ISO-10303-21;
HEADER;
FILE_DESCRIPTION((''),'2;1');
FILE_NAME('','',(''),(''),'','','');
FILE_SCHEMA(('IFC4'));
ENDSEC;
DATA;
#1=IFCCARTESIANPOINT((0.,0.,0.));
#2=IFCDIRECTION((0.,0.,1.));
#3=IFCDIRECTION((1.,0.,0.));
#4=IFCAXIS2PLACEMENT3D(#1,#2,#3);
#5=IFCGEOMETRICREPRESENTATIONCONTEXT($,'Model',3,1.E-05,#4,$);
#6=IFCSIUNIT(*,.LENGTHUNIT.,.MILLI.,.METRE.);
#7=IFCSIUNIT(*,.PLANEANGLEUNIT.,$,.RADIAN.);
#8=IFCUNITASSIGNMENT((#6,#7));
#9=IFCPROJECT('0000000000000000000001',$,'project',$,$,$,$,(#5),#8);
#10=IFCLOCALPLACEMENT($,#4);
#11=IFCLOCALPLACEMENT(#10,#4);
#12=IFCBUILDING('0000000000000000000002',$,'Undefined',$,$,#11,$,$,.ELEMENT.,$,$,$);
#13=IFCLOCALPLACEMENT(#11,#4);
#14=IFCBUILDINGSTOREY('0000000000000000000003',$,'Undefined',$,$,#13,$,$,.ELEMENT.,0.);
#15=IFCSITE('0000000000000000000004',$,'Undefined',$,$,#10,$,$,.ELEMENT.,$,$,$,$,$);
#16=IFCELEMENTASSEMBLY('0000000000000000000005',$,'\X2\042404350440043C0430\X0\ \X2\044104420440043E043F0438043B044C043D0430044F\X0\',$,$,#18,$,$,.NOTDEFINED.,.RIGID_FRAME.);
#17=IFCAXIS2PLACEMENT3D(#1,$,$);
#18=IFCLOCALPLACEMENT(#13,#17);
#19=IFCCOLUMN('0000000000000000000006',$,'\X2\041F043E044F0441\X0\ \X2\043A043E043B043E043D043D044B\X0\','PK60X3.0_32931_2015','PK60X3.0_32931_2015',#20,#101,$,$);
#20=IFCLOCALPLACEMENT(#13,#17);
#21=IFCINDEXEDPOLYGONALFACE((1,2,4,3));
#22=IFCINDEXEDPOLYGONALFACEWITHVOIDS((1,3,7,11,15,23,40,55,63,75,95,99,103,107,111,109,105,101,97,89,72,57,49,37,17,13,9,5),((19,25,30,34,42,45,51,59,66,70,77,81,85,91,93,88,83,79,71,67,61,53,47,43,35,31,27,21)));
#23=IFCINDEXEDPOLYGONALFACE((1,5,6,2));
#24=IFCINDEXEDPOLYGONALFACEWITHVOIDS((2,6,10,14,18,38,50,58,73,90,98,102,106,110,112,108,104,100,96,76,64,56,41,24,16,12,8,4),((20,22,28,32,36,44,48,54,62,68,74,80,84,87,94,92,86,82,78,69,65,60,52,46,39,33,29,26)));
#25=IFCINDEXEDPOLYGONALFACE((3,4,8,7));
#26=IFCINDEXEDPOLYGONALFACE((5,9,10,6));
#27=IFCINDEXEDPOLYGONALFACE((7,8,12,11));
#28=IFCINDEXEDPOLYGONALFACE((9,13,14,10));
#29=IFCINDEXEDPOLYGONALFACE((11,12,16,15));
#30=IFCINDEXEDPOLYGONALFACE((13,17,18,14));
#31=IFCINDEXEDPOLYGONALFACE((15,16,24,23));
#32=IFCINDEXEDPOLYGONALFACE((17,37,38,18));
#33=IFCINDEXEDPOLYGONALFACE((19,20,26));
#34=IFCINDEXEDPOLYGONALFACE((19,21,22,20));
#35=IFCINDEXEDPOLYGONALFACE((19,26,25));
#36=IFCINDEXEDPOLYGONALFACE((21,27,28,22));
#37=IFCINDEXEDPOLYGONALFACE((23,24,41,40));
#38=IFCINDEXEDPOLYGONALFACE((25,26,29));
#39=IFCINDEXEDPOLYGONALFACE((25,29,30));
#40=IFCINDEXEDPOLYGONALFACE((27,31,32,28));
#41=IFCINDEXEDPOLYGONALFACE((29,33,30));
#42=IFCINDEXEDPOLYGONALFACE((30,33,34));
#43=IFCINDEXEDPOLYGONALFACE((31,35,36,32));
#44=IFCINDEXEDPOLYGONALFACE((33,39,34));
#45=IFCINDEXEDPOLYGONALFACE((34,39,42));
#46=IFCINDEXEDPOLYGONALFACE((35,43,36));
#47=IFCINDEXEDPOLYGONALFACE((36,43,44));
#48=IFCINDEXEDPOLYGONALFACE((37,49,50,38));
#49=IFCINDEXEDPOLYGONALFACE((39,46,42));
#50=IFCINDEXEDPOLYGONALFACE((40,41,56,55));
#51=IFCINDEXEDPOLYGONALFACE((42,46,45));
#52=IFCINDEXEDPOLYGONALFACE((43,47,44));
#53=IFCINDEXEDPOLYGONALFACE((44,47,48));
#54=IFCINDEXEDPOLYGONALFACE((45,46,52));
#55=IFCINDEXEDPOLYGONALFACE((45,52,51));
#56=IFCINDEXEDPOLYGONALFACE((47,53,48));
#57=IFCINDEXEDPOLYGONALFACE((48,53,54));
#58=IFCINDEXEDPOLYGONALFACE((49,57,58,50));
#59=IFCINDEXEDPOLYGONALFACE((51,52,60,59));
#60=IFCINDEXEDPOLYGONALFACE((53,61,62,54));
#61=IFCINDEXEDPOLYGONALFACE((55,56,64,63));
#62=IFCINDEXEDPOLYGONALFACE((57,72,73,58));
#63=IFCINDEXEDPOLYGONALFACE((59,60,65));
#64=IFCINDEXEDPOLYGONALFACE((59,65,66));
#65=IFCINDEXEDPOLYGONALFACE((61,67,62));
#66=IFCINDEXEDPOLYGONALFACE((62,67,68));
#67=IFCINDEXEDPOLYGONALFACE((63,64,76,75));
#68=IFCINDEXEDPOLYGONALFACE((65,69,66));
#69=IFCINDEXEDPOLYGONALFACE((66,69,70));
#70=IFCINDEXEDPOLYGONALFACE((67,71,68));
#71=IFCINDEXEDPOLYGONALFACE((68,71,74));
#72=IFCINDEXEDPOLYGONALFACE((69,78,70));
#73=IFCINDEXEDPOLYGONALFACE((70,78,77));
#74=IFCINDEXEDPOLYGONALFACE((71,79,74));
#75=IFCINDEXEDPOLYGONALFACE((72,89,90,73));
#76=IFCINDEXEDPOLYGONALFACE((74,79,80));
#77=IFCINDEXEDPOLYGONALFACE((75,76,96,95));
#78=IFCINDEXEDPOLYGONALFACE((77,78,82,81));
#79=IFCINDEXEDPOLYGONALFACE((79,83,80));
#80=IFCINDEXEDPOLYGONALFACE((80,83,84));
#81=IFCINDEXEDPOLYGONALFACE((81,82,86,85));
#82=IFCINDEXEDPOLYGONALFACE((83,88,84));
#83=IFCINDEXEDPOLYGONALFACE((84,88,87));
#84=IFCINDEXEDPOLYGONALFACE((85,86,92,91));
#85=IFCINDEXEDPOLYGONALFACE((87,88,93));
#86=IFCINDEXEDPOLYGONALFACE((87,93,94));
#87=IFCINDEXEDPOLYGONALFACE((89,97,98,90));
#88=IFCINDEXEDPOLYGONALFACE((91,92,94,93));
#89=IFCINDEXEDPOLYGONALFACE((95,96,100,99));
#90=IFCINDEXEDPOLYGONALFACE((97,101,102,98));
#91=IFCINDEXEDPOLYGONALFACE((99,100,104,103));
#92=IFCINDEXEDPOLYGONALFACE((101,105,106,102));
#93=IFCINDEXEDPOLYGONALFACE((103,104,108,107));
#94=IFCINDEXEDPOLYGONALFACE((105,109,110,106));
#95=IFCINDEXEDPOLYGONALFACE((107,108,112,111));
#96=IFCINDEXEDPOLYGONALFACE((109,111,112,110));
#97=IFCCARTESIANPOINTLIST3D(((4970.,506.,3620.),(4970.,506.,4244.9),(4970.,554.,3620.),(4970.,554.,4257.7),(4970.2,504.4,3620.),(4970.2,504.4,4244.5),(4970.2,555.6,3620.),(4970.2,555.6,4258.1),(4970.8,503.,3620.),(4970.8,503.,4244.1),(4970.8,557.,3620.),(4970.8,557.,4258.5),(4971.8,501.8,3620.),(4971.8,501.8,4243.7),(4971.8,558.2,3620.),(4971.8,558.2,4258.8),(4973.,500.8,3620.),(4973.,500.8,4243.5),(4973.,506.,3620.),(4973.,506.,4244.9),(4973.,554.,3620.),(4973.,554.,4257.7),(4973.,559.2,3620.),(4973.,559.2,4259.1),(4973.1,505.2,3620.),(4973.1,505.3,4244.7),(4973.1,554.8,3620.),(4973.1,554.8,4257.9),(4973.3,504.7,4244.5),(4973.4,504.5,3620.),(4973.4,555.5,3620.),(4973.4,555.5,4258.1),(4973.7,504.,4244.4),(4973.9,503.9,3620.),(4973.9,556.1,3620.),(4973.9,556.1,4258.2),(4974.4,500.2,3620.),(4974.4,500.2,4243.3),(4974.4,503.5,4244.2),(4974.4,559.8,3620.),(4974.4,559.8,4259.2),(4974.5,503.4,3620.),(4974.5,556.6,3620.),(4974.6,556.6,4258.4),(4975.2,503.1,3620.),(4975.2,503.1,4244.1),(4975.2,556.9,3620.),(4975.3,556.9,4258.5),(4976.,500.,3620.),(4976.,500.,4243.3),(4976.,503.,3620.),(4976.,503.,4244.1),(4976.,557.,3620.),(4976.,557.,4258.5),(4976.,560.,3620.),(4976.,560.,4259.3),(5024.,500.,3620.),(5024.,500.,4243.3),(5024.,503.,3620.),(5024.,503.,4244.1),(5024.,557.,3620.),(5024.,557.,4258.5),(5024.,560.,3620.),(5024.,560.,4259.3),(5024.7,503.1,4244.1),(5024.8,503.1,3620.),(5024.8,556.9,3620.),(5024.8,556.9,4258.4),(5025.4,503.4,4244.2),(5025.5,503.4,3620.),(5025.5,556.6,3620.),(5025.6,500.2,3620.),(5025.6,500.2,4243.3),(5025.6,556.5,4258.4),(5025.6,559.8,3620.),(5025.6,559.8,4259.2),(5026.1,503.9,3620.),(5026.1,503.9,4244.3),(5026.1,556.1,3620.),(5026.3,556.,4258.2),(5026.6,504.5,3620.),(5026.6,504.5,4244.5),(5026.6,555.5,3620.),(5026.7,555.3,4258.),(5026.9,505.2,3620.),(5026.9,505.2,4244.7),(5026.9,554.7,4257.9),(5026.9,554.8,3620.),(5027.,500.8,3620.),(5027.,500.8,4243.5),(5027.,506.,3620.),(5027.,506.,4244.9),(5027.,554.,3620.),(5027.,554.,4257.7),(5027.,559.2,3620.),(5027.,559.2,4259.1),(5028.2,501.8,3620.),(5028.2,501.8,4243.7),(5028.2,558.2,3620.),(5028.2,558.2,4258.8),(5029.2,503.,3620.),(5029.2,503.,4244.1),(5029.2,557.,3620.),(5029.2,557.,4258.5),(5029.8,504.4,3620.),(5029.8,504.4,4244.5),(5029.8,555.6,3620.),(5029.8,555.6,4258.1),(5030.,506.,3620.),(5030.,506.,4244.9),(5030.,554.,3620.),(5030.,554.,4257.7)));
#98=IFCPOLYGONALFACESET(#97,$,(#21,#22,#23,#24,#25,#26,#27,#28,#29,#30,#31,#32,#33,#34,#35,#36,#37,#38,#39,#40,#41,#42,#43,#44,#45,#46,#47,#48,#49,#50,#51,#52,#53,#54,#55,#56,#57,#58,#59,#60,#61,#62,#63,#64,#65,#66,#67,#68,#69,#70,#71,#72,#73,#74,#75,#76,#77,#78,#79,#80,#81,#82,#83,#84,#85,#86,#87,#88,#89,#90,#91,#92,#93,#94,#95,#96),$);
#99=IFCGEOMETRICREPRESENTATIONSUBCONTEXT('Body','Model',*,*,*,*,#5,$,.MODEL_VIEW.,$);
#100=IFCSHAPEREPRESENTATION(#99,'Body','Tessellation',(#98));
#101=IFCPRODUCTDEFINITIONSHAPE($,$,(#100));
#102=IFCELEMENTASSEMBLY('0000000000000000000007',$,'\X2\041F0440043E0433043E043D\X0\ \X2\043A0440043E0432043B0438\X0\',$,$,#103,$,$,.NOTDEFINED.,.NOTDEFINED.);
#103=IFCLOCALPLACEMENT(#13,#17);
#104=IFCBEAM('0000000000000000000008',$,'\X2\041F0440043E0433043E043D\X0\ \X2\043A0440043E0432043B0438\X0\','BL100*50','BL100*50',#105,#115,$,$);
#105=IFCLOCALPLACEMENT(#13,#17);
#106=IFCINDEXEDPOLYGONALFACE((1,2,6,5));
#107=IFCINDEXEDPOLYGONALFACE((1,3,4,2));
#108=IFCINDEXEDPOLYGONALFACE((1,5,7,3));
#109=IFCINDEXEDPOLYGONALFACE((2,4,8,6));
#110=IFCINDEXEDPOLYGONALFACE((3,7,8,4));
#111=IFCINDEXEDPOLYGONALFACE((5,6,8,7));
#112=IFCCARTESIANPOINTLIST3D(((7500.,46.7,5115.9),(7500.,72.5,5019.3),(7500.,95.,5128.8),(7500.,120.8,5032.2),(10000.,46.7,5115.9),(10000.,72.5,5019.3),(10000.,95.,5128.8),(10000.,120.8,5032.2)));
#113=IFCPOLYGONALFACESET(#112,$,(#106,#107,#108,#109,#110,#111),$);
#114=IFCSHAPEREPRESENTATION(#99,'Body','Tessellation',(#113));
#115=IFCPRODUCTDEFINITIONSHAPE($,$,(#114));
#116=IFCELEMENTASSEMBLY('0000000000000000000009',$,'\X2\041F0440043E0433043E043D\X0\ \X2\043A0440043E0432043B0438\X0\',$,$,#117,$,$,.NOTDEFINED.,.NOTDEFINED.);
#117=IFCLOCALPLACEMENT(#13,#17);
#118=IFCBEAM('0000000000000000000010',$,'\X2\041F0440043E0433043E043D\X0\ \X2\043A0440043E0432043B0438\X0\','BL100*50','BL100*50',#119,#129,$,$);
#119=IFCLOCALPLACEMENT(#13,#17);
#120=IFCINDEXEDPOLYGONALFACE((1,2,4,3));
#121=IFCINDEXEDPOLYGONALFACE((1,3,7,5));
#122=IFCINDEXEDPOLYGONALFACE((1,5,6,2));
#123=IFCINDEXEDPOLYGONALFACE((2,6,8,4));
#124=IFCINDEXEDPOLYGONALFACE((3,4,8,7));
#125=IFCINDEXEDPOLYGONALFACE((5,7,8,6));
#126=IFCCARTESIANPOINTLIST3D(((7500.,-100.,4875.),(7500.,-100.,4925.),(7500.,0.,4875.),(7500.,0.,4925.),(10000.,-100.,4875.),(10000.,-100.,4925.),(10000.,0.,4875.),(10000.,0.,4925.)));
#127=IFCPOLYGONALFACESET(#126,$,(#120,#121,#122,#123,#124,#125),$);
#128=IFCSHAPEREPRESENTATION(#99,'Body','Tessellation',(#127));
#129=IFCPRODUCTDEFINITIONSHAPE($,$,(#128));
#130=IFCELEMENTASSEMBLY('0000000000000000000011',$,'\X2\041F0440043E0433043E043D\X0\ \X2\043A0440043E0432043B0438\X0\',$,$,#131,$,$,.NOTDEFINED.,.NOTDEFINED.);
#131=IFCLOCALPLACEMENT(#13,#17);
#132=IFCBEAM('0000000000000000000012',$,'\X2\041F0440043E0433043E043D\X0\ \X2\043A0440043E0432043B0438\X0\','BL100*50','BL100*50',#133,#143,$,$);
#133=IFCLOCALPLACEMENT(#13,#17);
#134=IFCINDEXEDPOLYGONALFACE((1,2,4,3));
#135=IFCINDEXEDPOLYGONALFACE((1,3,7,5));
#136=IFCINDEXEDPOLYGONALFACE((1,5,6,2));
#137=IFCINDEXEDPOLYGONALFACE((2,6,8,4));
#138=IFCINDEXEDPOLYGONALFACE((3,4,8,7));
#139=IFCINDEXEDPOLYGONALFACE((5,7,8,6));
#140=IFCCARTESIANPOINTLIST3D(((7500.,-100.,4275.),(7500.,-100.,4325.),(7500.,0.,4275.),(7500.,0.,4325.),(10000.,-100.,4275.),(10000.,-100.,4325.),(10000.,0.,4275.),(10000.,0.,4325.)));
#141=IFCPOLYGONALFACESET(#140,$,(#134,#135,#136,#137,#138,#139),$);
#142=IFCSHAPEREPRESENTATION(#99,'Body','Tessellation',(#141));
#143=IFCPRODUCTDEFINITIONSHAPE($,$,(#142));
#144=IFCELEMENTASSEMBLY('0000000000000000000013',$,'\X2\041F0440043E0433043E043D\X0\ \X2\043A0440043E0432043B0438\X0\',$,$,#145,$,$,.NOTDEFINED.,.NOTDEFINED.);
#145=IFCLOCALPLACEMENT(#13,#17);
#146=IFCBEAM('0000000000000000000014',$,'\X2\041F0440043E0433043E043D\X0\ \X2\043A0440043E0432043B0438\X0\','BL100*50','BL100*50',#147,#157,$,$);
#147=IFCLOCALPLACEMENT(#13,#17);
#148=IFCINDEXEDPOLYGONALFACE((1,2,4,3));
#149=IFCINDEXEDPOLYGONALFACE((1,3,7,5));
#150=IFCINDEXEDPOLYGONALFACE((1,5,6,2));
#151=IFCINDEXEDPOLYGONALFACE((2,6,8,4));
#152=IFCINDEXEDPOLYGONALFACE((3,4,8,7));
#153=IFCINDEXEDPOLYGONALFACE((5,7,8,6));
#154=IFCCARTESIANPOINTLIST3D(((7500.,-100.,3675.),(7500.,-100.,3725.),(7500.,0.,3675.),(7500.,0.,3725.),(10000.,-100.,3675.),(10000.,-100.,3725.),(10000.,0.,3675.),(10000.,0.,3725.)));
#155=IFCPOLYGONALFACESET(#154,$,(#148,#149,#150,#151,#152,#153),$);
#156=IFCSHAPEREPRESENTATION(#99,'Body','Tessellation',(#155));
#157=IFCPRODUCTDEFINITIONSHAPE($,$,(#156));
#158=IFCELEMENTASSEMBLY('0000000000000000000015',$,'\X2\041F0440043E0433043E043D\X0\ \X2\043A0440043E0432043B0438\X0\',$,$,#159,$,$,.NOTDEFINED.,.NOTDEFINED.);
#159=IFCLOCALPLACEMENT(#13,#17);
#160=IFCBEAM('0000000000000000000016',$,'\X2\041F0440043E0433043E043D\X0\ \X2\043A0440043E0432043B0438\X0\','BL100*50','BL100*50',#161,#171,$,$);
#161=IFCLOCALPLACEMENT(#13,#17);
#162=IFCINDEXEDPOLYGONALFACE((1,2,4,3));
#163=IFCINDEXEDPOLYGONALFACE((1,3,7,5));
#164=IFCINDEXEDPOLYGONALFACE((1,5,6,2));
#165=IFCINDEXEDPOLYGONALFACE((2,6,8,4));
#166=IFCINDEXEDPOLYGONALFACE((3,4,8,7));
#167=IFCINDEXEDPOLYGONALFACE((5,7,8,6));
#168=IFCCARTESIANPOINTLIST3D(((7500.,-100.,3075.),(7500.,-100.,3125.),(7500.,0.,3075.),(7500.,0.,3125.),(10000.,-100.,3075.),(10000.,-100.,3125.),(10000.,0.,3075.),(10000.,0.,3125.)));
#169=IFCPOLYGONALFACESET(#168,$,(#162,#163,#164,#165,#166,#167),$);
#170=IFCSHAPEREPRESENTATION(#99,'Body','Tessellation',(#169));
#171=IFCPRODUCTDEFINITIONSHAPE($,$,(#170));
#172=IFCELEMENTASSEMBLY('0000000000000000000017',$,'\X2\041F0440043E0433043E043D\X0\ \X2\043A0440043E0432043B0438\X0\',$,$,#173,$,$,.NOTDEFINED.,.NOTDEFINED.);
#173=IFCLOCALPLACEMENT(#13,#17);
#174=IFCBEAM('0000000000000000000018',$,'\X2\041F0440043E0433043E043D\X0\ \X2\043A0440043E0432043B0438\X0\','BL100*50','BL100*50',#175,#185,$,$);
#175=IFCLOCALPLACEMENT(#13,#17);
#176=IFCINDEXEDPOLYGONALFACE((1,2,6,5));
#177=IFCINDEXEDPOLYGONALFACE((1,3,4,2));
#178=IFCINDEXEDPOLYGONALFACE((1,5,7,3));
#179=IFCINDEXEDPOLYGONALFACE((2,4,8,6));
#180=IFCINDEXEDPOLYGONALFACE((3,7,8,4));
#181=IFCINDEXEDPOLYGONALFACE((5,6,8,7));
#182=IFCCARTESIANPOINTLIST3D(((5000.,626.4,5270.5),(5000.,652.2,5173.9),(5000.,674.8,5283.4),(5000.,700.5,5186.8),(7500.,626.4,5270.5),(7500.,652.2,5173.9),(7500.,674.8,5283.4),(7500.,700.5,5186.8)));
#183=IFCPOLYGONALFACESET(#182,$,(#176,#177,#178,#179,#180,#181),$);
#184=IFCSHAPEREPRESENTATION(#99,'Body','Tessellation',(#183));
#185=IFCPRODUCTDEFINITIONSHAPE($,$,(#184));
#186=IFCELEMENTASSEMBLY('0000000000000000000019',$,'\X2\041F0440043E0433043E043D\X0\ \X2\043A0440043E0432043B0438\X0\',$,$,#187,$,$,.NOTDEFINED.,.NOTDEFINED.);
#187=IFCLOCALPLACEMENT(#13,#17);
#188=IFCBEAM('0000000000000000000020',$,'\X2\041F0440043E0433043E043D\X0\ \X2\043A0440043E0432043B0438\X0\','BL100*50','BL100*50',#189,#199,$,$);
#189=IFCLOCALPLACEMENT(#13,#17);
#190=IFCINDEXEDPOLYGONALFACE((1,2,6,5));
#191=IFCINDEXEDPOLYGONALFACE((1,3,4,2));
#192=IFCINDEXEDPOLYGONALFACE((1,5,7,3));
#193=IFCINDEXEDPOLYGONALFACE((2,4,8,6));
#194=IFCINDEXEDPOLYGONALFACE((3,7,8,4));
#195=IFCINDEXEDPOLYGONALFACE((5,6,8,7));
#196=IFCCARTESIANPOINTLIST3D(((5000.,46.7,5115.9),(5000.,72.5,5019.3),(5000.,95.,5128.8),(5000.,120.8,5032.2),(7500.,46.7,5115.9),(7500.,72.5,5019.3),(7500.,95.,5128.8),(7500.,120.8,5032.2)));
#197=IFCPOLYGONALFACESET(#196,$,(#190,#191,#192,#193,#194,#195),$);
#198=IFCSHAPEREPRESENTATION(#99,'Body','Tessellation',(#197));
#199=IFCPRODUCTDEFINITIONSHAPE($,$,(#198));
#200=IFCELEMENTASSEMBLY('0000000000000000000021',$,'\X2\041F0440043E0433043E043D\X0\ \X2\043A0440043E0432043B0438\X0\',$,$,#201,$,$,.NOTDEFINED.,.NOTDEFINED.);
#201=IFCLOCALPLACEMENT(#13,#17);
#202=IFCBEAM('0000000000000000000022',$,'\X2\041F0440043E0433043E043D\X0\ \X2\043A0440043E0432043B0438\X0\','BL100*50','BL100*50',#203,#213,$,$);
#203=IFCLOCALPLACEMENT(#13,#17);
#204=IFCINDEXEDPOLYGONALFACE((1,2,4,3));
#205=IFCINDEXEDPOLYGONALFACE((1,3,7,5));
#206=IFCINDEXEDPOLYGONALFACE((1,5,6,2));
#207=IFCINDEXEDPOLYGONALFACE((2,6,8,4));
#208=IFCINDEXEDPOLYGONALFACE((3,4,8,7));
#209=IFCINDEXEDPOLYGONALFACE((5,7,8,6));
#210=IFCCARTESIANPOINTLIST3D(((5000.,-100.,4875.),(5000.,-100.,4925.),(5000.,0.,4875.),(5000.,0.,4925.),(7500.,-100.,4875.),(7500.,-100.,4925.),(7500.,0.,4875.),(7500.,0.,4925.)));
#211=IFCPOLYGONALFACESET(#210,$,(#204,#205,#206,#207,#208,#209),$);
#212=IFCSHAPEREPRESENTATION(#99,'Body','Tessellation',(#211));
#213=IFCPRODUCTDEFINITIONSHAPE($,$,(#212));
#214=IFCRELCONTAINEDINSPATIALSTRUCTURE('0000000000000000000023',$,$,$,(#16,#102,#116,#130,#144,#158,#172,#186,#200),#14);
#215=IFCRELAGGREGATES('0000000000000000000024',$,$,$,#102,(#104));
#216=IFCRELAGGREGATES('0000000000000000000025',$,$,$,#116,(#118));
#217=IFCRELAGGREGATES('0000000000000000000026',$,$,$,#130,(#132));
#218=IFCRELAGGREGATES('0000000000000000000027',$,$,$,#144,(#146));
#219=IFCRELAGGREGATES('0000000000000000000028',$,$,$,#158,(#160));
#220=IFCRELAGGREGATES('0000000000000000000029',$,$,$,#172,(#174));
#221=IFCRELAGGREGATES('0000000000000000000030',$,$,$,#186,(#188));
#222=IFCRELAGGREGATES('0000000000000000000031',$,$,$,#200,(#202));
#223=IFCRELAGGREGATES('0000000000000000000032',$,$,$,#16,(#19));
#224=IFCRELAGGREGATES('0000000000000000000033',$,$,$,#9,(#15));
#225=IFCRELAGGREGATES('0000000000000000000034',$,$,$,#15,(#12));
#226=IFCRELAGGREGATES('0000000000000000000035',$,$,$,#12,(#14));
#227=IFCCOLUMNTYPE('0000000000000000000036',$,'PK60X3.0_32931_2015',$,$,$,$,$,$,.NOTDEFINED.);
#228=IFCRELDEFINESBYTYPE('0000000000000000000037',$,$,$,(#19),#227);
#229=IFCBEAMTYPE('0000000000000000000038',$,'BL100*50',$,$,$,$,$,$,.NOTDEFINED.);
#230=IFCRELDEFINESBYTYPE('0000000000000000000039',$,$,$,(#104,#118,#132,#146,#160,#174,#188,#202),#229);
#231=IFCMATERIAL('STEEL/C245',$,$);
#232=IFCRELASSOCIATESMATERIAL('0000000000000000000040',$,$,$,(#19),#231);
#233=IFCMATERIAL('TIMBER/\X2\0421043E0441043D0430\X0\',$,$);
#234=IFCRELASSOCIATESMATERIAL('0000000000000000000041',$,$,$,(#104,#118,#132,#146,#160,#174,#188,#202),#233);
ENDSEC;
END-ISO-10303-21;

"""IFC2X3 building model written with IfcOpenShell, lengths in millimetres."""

from ifc_helpers import new_model, si_unit, frame, origin_with_axes, origin_2d_with_axis, place, context, subcontext, project, spatial, rectangle, hollow_rectangle, extrude, clip, halfspace, material, type_object, element, aggregate, save


model = new_model("IFC2X3")

# Units and contexts
model_context = context("Model", 3, precision=1e-05, world=origin_with_axes())
body_context = subcontext(model_context, "Body", "Model", "MODEL_VIEW")
ifc_project = project(units=[si_unit("LENGTHUNIT", "METRE", prefix="MILLI"), si_unit("PLANEANGLEUNIT", "RADIAN")], contexts=[model_context])

# Site, building, storey
site_placement = place(None, origin_with_axes())
site = spatial("IfcSite", under=ifc_project, at=site_placement, Name="Undefined", CompositionType="ELEMENT")
building_placement = place(site_placement, origin_with_axes())
building = spatial("IfcBuilding", under=site, at=building_placement, Name="Undefined", CompositionType="ELEMENT")
storey_placement = place(building_placement, origin_with_axes())
storey = spatial("IfcBuildingStorey", under=building, at=storey_placement, Name="Undefined", CompositionType="ELEMENT", Elevation=0.0)

# Shared definitions
ifc_material_1 = material(Name="STEEL/C245")
column_type = type_object("IfcColumnType", Name="PK60X3.0_32931_2015", PredefinedType="NOTDEFINED")

# Element assembly, column
assembly_1_placement = place(storey_placement, origin_with_axes())
assembly_1 = element("IfcElementAssembly", 1, at=assembly_1_placement, inside=storey, Name="Ферма стропильная", AssemblyPlace="NOTDEFINED", PredefinedType="RIGID_FRAME")
column_1_placement = place(assembly_1_placement, frame((5000.0, 530.0, 3620.0), z_axis=(0.0, 0.0, 1.0), x_axis=(-1.0, 0.0, 0.0)))
column_1 = element("IfcColumn", 2, at=column_1_placement, type_object=column_type, material=ifc_material_1, Name="Пояс колонны", Description="PK60X3.0_32931_2015", ObjectType="PK60X3.0_32931_2015", context=body_context, shape_type="Clipping", body=[
    clip(extrude(hollow_rectangle(XDim=60.0, YDim=60.0, WallThickness=3.0, InnerFilletRadius=3.0, OuterFilletRadius=6.0, at=origin_2d_with_axis()), frame((0.0, 0.0, 639.4), z_axis=(0.0, 0.0, -1.0), x_axis=(0.0, 1.0, 0.0)), (0.0, 0.0, 1.0), 639.4), halfspace(frame((0.0, 57.3, 616.0), z_axis=(0.0, -0.257663, -0.966235), x_axis=(-1.0, 0.0, 0.0)), True)),
])

# Element assemblies, beams
assembly_2_placement = place(storey_placement, origin_with_axes())
assembly_2 = element("IfcElementAssembly", 3, at=assembly_2_placement, inside=storey, Name="Прогон кровли", AssemblyPlace="NOTDEFINED", PredefinedType="NOTDEFINED")
ifc_material_2 = material(Name="TIMBER/Сосна")
beam_type_1 = type_object("IfcBeamType", Name="BL100*50", PredefinedType="NOTDEFINED")
beam_1_placement = place(assembly_2_placement, frame((7500.0, 83.7, 5074.1), z_axis=(0.0, 0.257663, -0.966235), x_axis=(1.0, 0.0, 0.0)))
beam_1 = element("IfcBeam", 4, at=beam_1_placement, type_object=beam_type_1, material=ifc_material_2, Name="Прогон кровли", Description="BL100*50", ObjectType="BL100*50", context=body_context, shape_type="SweptSolid", body=[
    extrude(rectangle(XDim=50.0, YDim=100.0, at=origin_2d_with_axis()), frame((2500.0, 0.0, 0.0), z_axis=(-1.0, 0.0, 0.0), x_axis=(0.0, -1.0, 0.0)), (0.0, 0.0, 1.0), 2500.0),
])
aggregate(assembly_2, [beam_1])
assembly_3_placement = place(storey_placement, origin_with_axes())
assembly_3 = element("IfcElementAssembly", 5, at=assembly_3_placement, inside=storey, Name="Прогон кровли", AssemblyPlace="NOTDEFINED", PredefinedType="NOTDEFINED")
beam_2_placement = place(assembly_3_placement, frame((7500.0, -50.0, 4900.0), z_axis=(0.0, -1.0, 0.0), x_axis=(1.0, 0.0, 0.0)))
beam_2 = element("IfcBeam", 6, at=beam_2_placement, type_object=beam_type_1, material=ifc_material_2, Name="Прогон кровли", Description="BL100*50", ObjectType="BL100*50", context=body_context, shape_type="SweptSolid", body=[
    extrude(rectangle(XDim=50.0, YDim=100.0, at=origin_2d_with_axis()), frame((2500.0, 0.0, 0.0), z_axis=(-1.0, 0.0, 0.0), x_axis=(0.0, -1.0, 0.0)), (0.0, 0.0, 1.0), 2500.0),
])
aggregate(assembly_3, [beam_2])
assembly_4_placement = place(storey_placement, origin_with_axes())
assembly_4 = element("IfcElementAssembly", 7, at=assembly_4_placement, inside=storey, Name="Прогон кровли", AssemblyPlace="NOTDEFINED", PredefinedType="NOTDEFINED")
beam_3_placement = place(assembly_4_placement, frame((7500.0, -50.0, 4300.0), z_axis=(0.0, -1.0, 0.0), x_axis=(1.0, 0.0, 0.0)))
beam_3 = element("IfcBeam", 8, at=beam_3_placement, type_object=beam_type_1, material=ifc_material_2, Name="Прогон кровли", Description="BL100*50", ObjectType="BL100*50", context=body_context, shape_type="SweptSolid", body=[
    extrude(rectangle(XDim=50.0, YDim=100.0, at=origin_2d_with_axis()), frame((2500.0, 0.0, 0.0), z_axis=(-1.0, 0.0, 0.0), x_axis=(0.0, -1.0, 0.0)), (0.0, 0.0, 1.0), 2500.0),
])
aggregate(assembly_4, [beam_3])
assembly_5_placement = place(storey_placement, origin_with_axes())
assembly_5 = element("IfcElementAssembly", 9, at=assembly_5_placement, inside=storey, Name="Прогон кровли", AssemblyPlace="NOTDEFINED", PredefinedType="NOTDEFINED")
beam_4_placement = place(assembly_5_placement, frame((7500.0, -50.0, 3700.0), z_axis=(0.0, -1.0, 0.0), x_axis=(1.0, 0.0, 0.0)))
beam_4 = element("IfcBeam", 10, at=beam_4_placement, type_object=beam_type_1, material=ifc_material_2, Name="Прогон кровли", Description="BL100*50", ObjectType="BL100*50", context=body_context, shape_type="SweptSolid", body=[
    extrude(rectangle(XDim=50.0, YDim=100.0, at=origin_2d_with_axis()), frame((2500.0, 0.0, 0.0), z_axis=(-1.0, 0.0, 0.0), x_axis=(0.0, -1.0, 0.0)), (0.0, 0.0, 1.0), 2500.0),
])
aggregate(assembly_5, [beam_4])
assembly_6_placement = place(storey_placement, origin_with_axes())
assembly_6 = element("IfcElementAssembly", 11, at=assembly_6_placement, inside=storey, Name="Прогон кровли", AssemblyPlace="NOTDEFINED", PredefinedType="NOTDEFINED")
beam_5_placement = place(assembly_6_placement, frame((7500.0, -50.0, 3100.0), z_axis=(0.0, -1.0, 0.0), x_axis=(1.0, 0.0, 0.0)))
beam_5 = element("IfcBeam", 12, at=beam_5_placement, type_object=beam_type_1, material=ifc_material_2, Name="Прогон кровли", Description="BL100*50", ObjectType="BL100*50", context=body_context, shape_type="SweptSolid", body=[
    extrude(rectangle(XDim=50.0, YDim=100.0, at=origin_2d_with_axis()), frame((2500.0, 0.0, 0.0), z_axis=(-1.0, 0.0, 0.0), x_axis=(0.0, -1.0, 0.0)), (0.0, 0.0, 1.0), 2500.0),
])
aggregate(assembly_6, [beam_5])
assembly_7_placement = place(storey_placement, origin_with_axes())
assembly_7 = element("IfcElementAssembly", 13, at=assembly_7_placement, inside=storey, Name="Прогон кровли", AssemblyPlace="NOTDEFINED", PredefinedType="NOTDEFINED")
beam_6_placement = place(assembly_7_placement, frame((5000.0, 663.5, 5228.7), z_axis=(0.0, 0.257663, -0.966235), x_axis=(1.0, 0.0, 0.0)))
beam_6 = element("IfcBeam", 14, at=beam_6_placement, type_object=beam_type_1, material=ifc_material_2, Name="Прогон кровли", Description="BL100*50", ObjectType="BL100*50", context=body_context, shape_type="SweptSolid", body=[
    extrude(rectangle(XDim=50.0, YDim=100.0, at=origin_2d_with_axis()), frame((2500.0, 0.0, 0.0), z_axis=(-1.0, 0.0, 0.0), x_axis=(0.0, -1.0, 0.0)), (0.0, 0.0, 1.0), 2500.0),
])
aggregate(assembly_7, [beam_6])
assembly_8_placement = place(storey_placement, origin_with_axes())
assembly_8 = element("IfcElementAssembly", 15, at=assembly_8_placement, inside=storey, Name="Прогон кровли", AssemblyPlace="NOTDEFINED", PredefinedType="NOTDEFINED")
beam_7_placement = place(assembly_8_placement, frame((5000.0, 83.7, 5074.1), z_axis=(0.0, 0.257663, -0.966235), x_axis=(1.0, 0.0, 0.0)))
beam_7 = element("IfcBeam", 16, at=beam_7_placement, type_object=beam_type_1, material=ifc_material_2, Name="Прогон кровли", Description="BL100*50", ObjectType="BL100*50", context=body_context, shape_type="SweptSolid", body=[
    extrude(rectangle(XDim=50.0, YDim=100.0, at=origin_2d_with_axis()), frame((2500.0, 0.0, 0.0), z_axis=(-1.0, 0.0, 0.0), x_axis=(0.0, -1.0, 0.0)), (0.0, 0.0, 1.0), 2500.0),
])
aggregate(assembly_8, [beam_7])
assembly_9_placement = place(storey_placement, origin_with_axes())
assembly_9 = element("IfcElementAssembly", 17, at=assembly_9_placement, inside=storey, Name="Прогон кровли", AssemblyPlace="NOTDEFINED", PredefinedType="NOTDEFINED")
beam_8_placement = place(assembly_9_placement, frame((5000.0, -50.0, 4900.0), z_axis=(0.0, -1.0, 0.0), x_axis=(1.0, 0.0, 0.0)))
beam_8 = element("IfcBeam", 18, at=beam_8_placement, type_object=beam_type_1, material=ifc_material_2, Name="Прогон кровли", Description="BL100*50", ObjectType="BL100*50", context=body_context, shape_type="SweptSolid", body=[
    extrude(rectangle(XDim=50.0, YDim=100.0, at=origin_2d_with_axis()), frame((2500.0, 0.0, 0.0), z_axis=(-1.0, 0.0, 0.0), x_axis=(0.0, -1.0, 0.0)), (0.0, 0.0, 1.0), 2500.0),
])
aggregate(assembly_9, [beam_8])

aggregate(assembly_1, [column_1])

save(model, "model.ifc")
